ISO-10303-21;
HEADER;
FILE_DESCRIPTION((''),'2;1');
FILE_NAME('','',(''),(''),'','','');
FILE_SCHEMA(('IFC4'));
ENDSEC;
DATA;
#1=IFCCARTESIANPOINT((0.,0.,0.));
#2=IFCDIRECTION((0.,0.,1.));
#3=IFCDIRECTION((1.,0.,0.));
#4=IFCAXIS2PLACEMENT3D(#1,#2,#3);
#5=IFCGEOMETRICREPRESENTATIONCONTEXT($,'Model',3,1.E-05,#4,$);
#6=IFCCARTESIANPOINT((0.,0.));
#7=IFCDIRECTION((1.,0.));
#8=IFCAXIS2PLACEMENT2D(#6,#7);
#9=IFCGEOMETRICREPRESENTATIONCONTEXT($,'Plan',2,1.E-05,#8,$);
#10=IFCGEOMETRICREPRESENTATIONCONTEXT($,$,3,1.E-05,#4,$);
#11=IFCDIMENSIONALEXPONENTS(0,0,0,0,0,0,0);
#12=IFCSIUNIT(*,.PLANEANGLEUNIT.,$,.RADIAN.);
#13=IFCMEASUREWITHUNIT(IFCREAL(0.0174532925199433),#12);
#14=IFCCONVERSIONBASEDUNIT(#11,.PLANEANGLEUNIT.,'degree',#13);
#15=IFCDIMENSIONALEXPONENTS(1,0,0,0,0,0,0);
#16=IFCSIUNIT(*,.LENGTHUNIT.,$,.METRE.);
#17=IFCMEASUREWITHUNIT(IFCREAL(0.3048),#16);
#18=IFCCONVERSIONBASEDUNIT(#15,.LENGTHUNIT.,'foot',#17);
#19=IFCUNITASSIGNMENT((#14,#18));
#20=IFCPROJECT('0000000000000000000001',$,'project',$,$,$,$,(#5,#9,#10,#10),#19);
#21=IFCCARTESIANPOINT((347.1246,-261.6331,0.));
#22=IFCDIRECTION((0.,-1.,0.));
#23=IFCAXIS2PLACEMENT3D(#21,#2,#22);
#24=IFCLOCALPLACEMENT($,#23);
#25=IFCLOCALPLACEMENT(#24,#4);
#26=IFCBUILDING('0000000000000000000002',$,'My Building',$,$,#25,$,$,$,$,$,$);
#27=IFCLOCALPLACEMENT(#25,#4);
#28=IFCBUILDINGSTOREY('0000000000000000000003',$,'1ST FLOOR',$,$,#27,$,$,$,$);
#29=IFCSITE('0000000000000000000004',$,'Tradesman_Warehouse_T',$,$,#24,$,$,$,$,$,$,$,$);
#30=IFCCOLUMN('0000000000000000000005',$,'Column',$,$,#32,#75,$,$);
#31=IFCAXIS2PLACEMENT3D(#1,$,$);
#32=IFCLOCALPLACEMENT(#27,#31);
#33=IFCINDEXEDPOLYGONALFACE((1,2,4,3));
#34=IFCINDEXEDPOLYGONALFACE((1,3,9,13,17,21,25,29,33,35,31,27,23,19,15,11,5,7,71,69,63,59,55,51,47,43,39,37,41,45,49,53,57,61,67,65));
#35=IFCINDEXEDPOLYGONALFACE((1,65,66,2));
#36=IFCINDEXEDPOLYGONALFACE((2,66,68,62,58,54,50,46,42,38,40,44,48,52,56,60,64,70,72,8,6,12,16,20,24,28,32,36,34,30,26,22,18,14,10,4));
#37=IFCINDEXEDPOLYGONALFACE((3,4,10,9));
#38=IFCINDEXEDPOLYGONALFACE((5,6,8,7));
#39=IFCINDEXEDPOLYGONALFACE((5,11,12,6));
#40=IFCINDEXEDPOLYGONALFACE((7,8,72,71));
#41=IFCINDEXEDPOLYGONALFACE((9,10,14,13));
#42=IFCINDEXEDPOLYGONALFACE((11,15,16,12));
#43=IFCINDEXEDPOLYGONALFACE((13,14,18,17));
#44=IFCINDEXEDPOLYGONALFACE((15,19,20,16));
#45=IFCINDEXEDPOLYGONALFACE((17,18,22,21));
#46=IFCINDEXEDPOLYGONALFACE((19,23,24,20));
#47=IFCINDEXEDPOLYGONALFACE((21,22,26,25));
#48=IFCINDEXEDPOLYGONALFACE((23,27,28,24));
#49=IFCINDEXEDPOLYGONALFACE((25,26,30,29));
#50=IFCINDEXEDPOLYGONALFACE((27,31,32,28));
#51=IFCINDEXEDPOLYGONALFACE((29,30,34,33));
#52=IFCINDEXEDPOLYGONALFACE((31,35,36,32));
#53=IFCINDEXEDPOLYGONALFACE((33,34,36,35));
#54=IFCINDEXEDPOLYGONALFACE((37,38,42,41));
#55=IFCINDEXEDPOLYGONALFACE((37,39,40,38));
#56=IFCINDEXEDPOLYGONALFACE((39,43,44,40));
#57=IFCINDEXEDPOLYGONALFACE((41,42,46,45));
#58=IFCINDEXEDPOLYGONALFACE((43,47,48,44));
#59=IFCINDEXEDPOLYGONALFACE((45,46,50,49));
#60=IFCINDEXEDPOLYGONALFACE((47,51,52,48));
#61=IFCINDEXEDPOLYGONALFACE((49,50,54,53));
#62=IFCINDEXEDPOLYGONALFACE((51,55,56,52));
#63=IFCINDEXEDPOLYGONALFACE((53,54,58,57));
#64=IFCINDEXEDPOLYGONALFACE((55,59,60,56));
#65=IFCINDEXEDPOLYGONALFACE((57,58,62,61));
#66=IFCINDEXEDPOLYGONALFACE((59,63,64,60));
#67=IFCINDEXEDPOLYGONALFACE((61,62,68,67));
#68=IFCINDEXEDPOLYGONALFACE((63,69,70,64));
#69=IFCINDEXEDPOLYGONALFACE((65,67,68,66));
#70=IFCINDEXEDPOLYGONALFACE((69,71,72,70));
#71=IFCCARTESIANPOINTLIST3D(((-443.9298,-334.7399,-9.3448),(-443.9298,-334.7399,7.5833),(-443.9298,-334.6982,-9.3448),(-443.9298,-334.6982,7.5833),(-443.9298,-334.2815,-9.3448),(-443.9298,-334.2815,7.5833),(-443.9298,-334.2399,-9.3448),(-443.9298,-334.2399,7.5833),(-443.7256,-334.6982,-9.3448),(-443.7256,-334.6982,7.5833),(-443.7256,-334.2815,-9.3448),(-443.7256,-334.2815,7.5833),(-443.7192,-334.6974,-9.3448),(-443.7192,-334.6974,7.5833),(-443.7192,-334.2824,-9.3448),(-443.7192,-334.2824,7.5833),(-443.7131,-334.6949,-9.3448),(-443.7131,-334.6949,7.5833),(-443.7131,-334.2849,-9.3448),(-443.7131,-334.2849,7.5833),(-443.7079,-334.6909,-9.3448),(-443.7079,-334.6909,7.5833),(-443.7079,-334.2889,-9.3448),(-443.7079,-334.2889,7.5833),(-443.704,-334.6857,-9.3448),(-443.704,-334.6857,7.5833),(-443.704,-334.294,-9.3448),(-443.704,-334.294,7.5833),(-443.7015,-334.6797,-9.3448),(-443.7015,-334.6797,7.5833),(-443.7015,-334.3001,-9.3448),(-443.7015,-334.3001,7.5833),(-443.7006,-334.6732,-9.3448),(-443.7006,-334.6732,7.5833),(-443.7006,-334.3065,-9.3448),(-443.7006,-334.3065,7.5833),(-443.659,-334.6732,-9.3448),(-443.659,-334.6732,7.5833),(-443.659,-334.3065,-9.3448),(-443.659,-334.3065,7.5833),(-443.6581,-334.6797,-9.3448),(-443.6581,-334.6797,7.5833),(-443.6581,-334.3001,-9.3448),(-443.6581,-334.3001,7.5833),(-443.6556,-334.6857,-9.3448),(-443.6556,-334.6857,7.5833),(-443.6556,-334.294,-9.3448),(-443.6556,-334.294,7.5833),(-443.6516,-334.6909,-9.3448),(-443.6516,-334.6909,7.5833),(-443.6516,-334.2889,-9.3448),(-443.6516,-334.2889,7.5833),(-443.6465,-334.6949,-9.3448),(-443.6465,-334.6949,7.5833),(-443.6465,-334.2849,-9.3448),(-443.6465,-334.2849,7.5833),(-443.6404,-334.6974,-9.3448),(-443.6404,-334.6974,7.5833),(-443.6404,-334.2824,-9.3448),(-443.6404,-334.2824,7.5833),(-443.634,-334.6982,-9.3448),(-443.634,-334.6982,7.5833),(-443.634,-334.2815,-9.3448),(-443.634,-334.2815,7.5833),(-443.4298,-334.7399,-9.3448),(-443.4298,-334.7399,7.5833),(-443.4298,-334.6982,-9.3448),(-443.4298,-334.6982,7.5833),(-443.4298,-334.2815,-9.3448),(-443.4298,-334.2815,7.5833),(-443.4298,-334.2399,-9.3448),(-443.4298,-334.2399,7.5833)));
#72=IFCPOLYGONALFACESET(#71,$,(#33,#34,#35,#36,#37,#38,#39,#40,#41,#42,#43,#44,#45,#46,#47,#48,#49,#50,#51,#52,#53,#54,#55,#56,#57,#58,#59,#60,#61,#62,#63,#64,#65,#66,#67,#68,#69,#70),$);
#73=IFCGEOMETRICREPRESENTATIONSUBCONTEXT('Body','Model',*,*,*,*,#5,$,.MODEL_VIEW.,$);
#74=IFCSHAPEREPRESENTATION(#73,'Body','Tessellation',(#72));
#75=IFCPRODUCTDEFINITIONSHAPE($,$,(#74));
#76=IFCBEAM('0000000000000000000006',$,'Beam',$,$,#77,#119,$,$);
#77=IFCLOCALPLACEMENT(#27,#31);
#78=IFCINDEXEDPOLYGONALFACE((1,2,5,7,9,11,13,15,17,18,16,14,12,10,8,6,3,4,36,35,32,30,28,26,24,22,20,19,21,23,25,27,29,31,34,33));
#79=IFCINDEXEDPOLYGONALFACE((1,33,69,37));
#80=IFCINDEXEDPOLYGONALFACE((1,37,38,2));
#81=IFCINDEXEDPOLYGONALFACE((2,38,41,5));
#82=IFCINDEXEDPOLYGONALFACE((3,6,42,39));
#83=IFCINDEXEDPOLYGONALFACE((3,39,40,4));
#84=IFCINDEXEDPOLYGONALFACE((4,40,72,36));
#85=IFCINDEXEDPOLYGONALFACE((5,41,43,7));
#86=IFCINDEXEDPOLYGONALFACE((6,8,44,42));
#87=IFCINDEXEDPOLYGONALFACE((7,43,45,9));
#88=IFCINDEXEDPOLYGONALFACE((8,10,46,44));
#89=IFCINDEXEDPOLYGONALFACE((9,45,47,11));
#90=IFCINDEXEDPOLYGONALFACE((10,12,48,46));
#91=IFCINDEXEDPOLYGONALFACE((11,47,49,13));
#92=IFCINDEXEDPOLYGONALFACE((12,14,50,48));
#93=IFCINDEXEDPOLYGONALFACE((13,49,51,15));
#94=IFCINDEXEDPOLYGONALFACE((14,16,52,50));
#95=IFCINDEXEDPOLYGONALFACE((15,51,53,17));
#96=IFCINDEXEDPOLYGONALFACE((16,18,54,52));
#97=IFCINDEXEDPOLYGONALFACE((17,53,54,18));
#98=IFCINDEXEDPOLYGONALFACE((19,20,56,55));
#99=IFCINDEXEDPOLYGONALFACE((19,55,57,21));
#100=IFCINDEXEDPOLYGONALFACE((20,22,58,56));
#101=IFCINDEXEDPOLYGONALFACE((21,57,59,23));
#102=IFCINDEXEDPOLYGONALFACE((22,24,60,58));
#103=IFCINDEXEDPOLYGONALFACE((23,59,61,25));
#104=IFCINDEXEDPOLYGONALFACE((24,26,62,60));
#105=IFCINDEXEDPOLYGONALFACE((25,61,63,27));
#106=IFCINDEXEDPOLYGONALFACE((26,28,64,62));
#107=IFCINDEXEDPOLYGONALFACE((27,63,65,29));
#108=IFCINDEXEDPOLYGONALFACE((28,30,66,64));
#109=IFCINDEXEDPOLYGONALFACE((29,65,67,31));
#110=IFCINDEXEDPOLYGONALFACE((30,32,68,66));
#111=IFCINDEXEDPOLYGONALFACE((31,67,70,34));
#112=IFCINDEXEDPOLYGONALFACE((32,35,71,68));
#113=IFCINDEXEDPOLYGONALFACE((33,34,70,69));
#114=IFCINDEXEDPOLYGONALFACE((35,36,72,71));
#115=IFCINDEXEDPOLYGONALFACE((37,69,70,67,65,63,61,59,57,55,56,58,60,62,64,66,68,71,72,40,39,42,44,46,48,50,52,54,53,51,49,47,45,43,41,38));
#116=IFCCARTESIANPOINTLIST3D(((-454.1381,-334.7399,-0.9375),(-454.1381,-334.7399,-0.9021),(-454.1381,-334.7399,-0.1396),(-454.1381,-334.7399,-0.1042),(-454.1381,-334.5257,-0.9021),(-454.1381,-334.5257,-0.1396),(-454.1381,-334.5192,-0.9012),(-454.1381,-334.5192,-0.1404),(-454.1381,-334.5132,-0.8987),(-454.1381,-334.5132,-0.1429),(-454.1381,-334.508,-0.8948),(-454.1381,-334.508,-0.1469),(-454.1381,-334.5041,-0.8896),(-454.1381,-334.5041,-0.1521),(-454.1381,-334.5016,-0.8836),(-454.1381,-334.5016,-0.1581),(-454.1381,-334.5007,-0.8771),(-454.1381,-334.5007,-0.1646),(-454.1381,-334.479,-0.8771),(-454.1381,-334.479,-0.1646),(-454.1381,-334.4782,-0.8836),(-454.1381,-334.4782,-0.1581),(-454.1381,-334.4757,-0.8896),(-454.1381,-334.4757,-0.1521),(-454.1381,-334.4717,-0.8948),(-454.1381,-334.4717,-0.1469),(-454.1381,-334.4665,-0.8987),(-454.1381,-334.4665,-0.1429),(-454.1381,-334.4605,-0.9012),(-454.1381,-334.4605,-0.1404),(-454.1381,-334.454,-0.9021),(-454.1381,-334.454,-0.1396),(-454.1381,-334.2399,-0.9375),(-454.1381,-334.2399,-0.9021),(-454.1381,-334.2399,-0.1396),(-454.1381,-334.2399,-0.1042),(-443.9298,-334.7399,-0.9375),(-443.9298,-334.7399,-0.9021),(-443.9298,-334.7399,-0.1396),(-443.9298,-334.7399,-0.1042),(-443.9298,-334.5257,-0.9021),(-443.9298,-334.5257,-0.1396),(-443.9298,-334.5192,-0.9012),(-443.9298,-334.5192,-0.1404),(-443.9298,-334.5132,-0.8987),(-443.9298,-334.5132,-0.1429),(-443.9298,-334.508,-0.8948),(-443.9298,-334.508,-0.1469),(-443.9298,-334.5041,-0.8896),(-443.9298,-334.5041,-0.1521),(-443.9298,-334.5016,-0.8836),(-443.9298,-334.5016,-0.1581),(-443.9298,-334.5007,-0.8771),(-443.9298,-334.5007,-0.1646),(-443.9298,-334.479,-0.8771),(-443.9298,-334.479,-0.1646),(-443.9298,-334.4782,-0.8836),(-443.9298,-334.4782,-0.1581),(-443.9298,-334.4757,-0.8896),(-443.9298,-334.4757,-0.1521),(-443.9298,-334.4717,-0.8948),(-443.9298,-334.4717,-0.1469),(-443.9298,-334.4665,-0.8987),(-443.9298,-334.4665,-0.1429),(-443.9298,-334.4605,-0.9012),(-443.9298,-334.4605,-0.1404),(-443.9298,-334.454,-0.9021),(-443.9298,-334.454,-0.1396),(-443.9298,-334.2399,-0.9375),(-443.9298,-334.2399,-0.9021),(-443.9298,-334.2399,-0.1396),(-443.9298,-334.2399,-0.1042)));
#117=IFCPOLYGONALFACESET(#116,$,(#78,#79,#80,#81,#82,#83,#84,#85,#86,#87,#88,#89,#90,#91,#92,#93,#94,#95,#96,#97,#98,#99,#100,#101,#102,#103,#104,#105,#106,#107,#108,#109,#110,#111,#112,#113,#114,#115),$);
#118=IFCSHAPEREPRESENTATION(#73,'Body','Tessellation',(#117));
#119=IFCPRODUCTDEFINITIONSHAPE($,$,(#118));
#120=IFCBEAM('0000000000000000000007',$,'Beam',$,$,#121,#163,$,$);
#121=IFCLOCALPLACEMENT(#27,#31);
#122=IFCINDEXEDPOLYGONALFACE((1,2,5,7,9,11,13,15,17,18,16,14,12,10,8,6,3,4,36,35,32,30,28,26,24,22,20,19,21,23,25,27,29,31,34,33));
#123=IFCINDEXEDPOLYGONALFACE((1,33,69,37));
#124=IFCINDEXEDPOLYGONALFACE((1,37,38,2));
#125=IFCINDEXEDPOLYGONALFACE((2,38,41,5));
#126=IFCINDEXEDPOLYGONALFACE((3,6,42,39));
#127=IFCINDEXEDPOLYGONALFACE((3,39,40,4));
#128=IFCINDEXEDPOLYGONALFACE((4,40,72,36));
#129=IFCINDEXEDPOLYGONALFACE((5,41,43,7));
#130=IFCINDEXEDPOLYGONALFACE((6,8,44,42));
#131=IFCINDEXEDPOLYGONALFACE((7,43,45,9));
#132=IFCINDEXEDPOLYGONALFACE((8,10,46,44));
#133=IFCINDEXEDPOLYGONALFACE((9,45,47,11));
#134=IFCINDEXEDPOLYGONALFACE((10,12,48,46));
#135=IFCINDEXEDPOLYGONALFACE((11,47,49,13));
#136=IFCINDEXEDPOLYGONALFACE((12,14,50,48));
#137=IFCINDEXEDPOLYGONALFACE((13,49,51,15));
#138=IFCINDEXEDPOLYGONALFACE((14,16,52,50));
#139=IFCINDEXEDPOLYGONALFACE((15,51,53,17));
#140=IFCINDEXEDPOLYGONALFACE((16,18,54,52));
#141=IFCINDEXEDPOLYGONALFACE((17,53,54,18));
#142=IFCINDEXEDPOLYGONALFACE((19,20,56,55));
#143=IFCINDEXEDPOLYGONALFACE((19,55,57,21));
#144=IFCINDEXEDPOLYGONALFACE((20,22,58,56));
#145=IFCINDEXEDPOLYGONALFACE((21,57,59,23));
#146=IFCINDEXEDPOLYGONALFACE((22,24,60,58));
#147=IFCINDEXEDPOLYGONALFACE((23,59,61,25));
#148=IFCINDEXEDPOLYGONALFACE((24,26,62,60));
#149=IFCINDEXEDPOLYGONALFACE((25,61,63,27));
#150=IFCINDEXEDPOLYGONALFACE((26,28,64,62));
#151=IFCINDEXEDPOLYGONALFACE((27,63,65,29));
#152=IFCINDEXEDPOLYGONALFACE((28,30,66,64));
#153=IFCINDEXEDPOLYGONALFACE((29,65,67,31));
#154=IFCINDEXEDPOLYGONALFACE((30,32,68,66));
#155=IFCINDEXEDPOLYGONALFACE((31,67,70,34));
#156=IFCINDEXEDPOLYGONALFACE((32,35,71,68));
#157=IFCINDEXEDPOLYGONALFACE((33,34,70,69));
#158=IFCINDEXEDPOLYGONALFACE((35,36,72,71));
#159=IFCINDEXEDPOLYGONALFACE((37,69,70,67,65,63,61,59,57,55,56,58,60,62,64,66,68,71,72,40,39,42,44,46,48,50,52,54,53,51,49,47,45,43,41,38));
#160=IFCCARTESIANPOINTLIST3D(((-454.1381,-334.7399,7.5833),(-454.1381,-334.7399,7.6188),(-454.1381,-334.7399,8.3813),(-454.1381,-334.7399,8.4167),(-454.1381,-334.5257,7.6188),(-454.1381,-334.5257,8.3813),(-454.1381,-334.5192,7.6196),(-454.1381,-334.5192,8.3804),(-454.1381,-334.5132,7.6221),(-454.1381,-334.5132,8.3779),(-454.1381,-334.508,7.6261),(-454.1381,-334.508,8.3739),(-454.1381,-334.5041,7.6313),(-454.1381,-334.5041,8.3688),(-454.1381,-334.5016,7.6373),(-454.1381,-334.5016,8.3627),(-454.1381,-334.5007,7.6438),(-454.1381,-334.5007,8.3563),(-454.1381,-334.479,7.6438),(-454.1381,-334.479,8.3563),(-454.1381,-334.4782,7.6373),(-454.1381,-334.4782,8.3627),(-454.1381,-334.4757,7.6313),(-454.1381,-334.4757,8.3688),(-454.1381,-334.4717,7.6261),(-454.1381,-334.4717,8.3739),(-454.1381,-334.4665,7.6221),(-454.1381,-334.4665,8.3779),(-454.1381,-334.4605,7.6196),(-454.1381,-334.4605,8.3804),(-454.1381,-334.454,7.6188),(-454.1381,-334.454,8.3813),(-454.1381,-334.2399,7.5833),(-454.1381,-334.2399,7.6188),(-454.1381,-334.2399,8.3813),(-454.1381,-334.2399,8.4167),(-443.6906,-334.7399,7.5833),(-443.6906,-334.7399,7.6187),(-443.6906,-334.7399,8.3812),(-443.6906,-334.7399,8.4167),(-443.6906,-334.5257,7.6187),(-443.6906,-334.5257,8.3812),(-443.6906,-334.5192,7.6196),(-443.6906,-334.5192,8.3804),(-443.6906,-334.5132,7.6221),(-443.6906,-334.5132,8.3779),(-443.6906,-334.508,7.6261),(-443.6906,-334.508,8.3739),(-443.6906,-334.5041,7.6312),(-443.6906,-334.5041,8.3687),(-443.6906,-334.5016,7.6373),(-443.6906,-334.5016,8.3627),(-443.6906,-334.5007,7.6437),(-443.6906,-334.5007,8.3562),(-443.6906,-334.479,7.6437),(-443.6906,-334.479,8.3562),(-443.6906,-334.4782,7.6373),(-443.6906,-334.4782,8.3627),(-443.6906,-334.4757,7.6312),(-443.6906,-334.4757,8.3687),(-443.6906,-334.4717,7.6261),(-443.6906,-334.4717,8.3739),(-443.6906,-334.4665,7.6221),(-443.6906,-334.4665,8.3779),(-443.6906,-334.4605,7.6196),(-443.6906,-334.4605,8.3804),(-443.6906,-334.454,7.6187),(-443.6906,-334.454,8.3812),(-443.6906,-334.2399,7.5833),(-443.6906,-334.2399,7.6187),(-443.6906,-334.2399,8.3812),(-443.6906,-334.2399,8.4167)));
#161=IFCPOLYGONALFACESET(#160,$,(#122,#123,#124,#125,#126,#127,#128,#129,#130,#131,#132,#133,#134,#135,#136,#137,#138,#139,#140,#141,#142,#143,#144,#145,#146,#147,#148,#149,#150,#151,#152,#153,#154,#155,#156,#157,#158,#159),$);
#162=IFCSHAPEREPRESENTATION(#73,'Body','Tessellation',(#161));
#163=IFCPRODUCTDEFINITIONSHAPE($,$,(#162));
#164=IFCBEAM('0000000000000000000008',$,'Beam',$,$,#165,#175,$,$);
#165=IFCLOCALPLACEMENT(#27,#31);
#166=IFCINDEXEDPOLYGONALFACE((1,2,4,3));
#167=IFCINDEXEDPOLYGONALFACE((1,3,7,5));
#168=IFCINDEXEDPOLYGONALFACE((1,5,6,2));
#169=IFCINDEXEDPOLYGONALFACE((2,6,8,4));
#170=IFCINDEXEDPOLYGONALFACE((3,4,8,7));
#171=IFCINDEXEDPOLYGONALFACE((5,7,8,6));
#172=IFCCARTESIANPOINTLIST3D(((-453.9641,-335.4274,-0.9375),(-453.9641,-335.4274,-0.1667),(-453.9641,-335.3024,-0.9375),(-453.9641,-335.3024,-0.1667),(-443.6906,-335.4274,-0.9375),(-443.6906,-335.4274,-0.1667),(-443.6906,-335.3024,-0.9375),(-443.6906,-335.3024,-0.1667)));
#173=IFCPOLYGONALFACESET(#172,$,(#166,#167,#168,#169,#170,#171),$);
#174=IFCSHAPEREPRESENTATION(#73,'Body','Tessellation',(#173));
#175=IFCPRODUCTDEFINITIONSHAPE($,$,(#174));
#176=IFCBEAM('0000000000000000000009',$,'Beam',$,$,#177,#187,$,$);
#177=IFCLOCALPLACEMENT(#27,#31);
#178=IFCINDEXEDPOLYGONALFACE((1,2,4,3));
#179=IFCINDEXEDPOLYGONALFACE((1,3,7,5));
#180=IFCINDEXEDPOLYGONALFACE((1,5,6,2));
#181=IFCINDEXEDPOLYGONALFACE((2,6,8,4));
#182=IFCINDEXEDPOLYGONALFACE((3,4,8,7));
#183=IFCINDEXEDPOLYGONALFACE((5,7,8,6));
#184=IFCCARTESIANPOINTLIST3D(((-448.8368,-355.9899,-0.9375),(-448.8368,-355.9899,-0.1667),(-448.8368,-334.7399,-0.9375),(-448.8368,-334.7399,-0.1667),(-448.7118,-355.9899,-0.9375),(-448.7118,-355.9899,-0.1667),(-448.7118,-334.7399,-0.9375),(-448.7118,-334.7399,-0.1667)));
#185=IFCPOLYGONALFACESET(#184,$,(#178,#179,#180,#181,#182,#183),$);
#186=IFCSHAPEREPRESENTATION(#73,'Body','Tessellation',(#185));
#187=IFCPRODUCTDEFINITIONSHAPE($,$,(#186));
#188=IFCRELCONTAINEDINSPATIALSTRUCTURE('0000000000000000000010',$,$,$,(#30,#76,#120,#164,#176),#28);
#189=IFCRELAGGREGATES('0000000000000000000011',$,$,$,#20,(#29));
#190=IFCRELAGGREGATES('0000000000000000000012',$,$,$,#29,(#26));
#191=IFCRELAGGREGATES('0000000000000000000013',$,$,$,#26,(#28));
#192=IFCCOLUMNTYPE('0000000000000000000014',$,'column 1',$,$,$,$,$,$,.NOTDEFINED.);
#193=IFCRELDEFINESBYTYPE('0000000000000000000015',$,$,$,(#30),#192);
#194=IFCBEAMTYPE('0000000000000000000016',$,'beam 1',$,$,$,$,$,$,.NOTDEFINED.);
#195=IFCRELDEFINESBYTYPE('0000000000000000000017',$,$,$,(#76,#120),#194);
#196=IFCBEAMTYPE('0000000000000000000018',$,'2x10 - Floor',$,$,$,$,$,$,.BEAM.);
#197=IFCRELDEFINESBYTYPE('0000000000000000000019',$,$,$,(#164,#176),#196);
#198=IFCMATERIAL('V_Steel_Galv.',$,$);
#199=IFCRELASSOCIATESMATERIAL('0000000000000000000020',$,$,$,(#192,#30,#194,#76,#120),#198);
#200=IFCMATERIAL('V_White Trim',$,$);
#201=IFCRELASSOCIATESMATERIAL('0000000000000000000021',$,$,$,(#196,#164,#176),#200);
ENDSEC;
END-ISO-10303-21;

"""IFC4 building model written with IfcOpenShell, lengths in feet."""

from ifc_helpers import new_model, entity, si_unit, converted_unit, frame, origin_with_axes, origin_2d_with_axis, place, context, subcontext, project, spatial, rectangle, i_section, extrude, material, material_profile, profile_set, profile_usage, type_object, element, save


model = new_model("IFC4")

# Units and contexts
model_context = context("Model", 3, precision=1e-05, world=origin_with_axes())
plan_context = context("Plan", 2, precision=1e-05, world=origin_2d_with_axis())
context_of_model = context(None, 3, precision=1e-05, world=origin_with_axes())
body_context = subcontext(model_context, "Body", "Model", "MODEL_VIEW")
ifc_project = project(units=[converted_unit("PLANEANGLEUNIT", "degree", entity("IfcReal", 0.0174532925199433), si_unit("PLANEANGLEUNIT", "RADIAN"), dimensions=[0, 0, 0, 0, 0, 0, 0]), converted_unit("LENGTHUNIT", "foot", entity("IfcReal", 0.3048), si_unit("LENGTHUNIT", "METRE"), dimensions=[1, 0, 0, 0, 0, 0, 0])], contexts=[model_context, plan_context, context_of_model, context_of_model])

# Site, building, storey
site_placement = place(None, frame((347.1246, -261.6331, 0.0), z_axis=(0.0, 0.0, 1.0), x_axis=(0.0, -1.0, 0.0)))
site = spatial("IfcSite", under=ifc_project, at=site_placement, Name="Tradesman_Warehouse_T")
building_placement = place(site_placement, frame((0.0, 0.0, 0.0), z_axis=(0.0, 0.0, 1.0), x_axis=(1.0, 0.0, 0.0)))
building = spatial("IfcBuilding", under=site, at=building_placement, Name="My Building")
storey_placement = place(building_placement, frame((0.0, 0.0, 0.0), z_axis=(0.0, 0.0, 1.0), x_axis=(1.0, 0.0, 0.0)))
storey = spatial("IfcBuildingStorey", under=building, at=storey_placement, Name="1ST FLOOR")

# Column
ifc_material_1 = material(Name="V_Steel_Galv.")
ifc_material_profile_1 = material_profile(ifc_material_1, i_section(OverallWidth=0.5, OverallDepth=0.5, WebThickness=0.0417, FlangeThickness=0.0417, FilletRadius=0.025))
ifc_profile_set_1 = profile_set([ifc_material_profile_1])
ifc_profile_usage_1 = profile_usage(ifc_profile_set_1, cardinal=5)
column_type = type_object("IfcColumnType", Name="column 1", PredefinedType="NOTDEFINED", material=ifc_profile_set_1)
column_placement = place(storey_placement, frame((-443.6798, -334.4899, -9.3448), z_axis=(0.0, 0.0, 1.0), x_axis=(1.0, 0.0, 0.0)))
element("IfcColumn", 1, at=column_placement, inside=storey, type_object=column_type, material=ifc_profile_usage_1, Name="Column", context=body_context, shape_type="SweptSolid", body=[
    extrude(i_section(OverallWidth=0.5, OverallDepth=0.5, WebThickness=0.0417, FlangeThickness=0.0417, FilletRadius=0.025), origin_with_axes(), (0.0, 0.0, 1.0), 16.9281),
])

# Beams
ifc_material_profile_2 = material_profile(ifc_material_1, i_section(OverallWidth=0.5, OverallDepth=0.8333, WebThickness=0.0217, FlangeThickness=0.0354, FilletRadius=0.025))
ifc_profile_set_2 = profile_set([ifc_material_profile_2])
ifc_profile_usage_2 = profile_usage(ifc_profile_set_2, cardinal=5)
beam_type_1 = type_object("IfcBeamType", Name="beam 1", PredefinedType="NOTDEFINED", material=ifc_profile_set_2)
beam_1_placement = place(storey_placement, frame((-454.1381, -334.4899, -0.5208), z_axis=(1.0, 0.0, 0.0), x_axis=(0.0, 1.0, 0.0)))
element("IfcBeam", 2, at=beam_1_placement, inside=storey, type_object=beam_type_1, material=ifc_profile_usage_2, Name="Beam", context=body_context, shape_type="SweptSolid", body=[
    extrude(i_section(OverallWidth=0.5, OverallDepth=0.8333, WebThickness=0.0217, FlangeThickness=0.0354, FilletRadius=0.025), origin_with_axes(), (0.0, 0.0, 1.0), 10.2084),
])
ifc_profile_usage_3 = profile_usage(ifc_profile_set_2, cardinal=5)
beam_2_placement = place(storey_placement, frame((-454.1381, -334.4899, 8.0), z_axis=(1.0, 0.0, 0.0), x_axis=(0.0, 1.0, 0.0)))
element("IfcBeam", 3, at=beam_2_placement, inside=storey, type_object=beam_type_1, material=ifc_profile_usage_3, Name="Beam", context=body_context, shape_type="SweptSolid", body=[
    extrude(i_section(OverallWidth=0.5, OverallDepth=0.8333, WebThickness=0.0217, FlangeThickness=0.0354, FilletRadius=0.025), origin_with_axes(), (0.0, 0.0, 1.0), 10.4475),
])
ifc_material_2 = material(Name="V_White Trim")
ifc_material_profile_3 = material_profile(ifc_material_2, rectangle(XDim=0.125, YDim=0.7708))
ifc_profile_set_3 = profile_set([ifc_material_profile_3])
ifc_profile_usage_4 = profile_usage(ifc_profile_set_3, cardinal=5)
beam_type_2 = type_object("IfcBeamType", Name="2x10 - Floor", PredefinedType="BEAM", material=ifc_profile_set_3)
beam_3_placement = place(storey_placement, frame((-453.9641, -335.3649, -0.5521), z_axis=(1.0, 0.0, 0.0), x_axis=(0.0, 1.0, 0.0)))
element("IfcBeam", 4, at=beam_3_placement, inside=storey, type_object=beam_type_2, material=ifc_profile_usage_4, Name="Beam", context=body_context, shape_type="SweptSolid", body=[
    extrude(rectangle(XDim=0.125, YDim=0.7708), origin_with_axes(), (0.0, 0.0, 1.0), 10.2735),
])
ifc_profile_usage_5 = profile_usage(ifc_profile_set_3, cardinal=5)
beam_4_placement = place(storey_placement, frame((-448.7743, -334.7399, -0.5521), z_axis=(0.0, -1.0, 0.0), x_axis=(1.0, 0.0, 0.0)))
element("IfcBeam", 5, at=beam_4_placement, inside=storey, type_object=beam_type_2, material=ifc_profile_usage_5, Name="Beam", context=body_context, shape_type="SweptSolid", body=[
    extrude(rectangle(XDim=0.125, YDim=0.7708), origin_with_axes(), (0.0, 0.0, 1.0), 21.25),
])

save(model, "model.ifc")
